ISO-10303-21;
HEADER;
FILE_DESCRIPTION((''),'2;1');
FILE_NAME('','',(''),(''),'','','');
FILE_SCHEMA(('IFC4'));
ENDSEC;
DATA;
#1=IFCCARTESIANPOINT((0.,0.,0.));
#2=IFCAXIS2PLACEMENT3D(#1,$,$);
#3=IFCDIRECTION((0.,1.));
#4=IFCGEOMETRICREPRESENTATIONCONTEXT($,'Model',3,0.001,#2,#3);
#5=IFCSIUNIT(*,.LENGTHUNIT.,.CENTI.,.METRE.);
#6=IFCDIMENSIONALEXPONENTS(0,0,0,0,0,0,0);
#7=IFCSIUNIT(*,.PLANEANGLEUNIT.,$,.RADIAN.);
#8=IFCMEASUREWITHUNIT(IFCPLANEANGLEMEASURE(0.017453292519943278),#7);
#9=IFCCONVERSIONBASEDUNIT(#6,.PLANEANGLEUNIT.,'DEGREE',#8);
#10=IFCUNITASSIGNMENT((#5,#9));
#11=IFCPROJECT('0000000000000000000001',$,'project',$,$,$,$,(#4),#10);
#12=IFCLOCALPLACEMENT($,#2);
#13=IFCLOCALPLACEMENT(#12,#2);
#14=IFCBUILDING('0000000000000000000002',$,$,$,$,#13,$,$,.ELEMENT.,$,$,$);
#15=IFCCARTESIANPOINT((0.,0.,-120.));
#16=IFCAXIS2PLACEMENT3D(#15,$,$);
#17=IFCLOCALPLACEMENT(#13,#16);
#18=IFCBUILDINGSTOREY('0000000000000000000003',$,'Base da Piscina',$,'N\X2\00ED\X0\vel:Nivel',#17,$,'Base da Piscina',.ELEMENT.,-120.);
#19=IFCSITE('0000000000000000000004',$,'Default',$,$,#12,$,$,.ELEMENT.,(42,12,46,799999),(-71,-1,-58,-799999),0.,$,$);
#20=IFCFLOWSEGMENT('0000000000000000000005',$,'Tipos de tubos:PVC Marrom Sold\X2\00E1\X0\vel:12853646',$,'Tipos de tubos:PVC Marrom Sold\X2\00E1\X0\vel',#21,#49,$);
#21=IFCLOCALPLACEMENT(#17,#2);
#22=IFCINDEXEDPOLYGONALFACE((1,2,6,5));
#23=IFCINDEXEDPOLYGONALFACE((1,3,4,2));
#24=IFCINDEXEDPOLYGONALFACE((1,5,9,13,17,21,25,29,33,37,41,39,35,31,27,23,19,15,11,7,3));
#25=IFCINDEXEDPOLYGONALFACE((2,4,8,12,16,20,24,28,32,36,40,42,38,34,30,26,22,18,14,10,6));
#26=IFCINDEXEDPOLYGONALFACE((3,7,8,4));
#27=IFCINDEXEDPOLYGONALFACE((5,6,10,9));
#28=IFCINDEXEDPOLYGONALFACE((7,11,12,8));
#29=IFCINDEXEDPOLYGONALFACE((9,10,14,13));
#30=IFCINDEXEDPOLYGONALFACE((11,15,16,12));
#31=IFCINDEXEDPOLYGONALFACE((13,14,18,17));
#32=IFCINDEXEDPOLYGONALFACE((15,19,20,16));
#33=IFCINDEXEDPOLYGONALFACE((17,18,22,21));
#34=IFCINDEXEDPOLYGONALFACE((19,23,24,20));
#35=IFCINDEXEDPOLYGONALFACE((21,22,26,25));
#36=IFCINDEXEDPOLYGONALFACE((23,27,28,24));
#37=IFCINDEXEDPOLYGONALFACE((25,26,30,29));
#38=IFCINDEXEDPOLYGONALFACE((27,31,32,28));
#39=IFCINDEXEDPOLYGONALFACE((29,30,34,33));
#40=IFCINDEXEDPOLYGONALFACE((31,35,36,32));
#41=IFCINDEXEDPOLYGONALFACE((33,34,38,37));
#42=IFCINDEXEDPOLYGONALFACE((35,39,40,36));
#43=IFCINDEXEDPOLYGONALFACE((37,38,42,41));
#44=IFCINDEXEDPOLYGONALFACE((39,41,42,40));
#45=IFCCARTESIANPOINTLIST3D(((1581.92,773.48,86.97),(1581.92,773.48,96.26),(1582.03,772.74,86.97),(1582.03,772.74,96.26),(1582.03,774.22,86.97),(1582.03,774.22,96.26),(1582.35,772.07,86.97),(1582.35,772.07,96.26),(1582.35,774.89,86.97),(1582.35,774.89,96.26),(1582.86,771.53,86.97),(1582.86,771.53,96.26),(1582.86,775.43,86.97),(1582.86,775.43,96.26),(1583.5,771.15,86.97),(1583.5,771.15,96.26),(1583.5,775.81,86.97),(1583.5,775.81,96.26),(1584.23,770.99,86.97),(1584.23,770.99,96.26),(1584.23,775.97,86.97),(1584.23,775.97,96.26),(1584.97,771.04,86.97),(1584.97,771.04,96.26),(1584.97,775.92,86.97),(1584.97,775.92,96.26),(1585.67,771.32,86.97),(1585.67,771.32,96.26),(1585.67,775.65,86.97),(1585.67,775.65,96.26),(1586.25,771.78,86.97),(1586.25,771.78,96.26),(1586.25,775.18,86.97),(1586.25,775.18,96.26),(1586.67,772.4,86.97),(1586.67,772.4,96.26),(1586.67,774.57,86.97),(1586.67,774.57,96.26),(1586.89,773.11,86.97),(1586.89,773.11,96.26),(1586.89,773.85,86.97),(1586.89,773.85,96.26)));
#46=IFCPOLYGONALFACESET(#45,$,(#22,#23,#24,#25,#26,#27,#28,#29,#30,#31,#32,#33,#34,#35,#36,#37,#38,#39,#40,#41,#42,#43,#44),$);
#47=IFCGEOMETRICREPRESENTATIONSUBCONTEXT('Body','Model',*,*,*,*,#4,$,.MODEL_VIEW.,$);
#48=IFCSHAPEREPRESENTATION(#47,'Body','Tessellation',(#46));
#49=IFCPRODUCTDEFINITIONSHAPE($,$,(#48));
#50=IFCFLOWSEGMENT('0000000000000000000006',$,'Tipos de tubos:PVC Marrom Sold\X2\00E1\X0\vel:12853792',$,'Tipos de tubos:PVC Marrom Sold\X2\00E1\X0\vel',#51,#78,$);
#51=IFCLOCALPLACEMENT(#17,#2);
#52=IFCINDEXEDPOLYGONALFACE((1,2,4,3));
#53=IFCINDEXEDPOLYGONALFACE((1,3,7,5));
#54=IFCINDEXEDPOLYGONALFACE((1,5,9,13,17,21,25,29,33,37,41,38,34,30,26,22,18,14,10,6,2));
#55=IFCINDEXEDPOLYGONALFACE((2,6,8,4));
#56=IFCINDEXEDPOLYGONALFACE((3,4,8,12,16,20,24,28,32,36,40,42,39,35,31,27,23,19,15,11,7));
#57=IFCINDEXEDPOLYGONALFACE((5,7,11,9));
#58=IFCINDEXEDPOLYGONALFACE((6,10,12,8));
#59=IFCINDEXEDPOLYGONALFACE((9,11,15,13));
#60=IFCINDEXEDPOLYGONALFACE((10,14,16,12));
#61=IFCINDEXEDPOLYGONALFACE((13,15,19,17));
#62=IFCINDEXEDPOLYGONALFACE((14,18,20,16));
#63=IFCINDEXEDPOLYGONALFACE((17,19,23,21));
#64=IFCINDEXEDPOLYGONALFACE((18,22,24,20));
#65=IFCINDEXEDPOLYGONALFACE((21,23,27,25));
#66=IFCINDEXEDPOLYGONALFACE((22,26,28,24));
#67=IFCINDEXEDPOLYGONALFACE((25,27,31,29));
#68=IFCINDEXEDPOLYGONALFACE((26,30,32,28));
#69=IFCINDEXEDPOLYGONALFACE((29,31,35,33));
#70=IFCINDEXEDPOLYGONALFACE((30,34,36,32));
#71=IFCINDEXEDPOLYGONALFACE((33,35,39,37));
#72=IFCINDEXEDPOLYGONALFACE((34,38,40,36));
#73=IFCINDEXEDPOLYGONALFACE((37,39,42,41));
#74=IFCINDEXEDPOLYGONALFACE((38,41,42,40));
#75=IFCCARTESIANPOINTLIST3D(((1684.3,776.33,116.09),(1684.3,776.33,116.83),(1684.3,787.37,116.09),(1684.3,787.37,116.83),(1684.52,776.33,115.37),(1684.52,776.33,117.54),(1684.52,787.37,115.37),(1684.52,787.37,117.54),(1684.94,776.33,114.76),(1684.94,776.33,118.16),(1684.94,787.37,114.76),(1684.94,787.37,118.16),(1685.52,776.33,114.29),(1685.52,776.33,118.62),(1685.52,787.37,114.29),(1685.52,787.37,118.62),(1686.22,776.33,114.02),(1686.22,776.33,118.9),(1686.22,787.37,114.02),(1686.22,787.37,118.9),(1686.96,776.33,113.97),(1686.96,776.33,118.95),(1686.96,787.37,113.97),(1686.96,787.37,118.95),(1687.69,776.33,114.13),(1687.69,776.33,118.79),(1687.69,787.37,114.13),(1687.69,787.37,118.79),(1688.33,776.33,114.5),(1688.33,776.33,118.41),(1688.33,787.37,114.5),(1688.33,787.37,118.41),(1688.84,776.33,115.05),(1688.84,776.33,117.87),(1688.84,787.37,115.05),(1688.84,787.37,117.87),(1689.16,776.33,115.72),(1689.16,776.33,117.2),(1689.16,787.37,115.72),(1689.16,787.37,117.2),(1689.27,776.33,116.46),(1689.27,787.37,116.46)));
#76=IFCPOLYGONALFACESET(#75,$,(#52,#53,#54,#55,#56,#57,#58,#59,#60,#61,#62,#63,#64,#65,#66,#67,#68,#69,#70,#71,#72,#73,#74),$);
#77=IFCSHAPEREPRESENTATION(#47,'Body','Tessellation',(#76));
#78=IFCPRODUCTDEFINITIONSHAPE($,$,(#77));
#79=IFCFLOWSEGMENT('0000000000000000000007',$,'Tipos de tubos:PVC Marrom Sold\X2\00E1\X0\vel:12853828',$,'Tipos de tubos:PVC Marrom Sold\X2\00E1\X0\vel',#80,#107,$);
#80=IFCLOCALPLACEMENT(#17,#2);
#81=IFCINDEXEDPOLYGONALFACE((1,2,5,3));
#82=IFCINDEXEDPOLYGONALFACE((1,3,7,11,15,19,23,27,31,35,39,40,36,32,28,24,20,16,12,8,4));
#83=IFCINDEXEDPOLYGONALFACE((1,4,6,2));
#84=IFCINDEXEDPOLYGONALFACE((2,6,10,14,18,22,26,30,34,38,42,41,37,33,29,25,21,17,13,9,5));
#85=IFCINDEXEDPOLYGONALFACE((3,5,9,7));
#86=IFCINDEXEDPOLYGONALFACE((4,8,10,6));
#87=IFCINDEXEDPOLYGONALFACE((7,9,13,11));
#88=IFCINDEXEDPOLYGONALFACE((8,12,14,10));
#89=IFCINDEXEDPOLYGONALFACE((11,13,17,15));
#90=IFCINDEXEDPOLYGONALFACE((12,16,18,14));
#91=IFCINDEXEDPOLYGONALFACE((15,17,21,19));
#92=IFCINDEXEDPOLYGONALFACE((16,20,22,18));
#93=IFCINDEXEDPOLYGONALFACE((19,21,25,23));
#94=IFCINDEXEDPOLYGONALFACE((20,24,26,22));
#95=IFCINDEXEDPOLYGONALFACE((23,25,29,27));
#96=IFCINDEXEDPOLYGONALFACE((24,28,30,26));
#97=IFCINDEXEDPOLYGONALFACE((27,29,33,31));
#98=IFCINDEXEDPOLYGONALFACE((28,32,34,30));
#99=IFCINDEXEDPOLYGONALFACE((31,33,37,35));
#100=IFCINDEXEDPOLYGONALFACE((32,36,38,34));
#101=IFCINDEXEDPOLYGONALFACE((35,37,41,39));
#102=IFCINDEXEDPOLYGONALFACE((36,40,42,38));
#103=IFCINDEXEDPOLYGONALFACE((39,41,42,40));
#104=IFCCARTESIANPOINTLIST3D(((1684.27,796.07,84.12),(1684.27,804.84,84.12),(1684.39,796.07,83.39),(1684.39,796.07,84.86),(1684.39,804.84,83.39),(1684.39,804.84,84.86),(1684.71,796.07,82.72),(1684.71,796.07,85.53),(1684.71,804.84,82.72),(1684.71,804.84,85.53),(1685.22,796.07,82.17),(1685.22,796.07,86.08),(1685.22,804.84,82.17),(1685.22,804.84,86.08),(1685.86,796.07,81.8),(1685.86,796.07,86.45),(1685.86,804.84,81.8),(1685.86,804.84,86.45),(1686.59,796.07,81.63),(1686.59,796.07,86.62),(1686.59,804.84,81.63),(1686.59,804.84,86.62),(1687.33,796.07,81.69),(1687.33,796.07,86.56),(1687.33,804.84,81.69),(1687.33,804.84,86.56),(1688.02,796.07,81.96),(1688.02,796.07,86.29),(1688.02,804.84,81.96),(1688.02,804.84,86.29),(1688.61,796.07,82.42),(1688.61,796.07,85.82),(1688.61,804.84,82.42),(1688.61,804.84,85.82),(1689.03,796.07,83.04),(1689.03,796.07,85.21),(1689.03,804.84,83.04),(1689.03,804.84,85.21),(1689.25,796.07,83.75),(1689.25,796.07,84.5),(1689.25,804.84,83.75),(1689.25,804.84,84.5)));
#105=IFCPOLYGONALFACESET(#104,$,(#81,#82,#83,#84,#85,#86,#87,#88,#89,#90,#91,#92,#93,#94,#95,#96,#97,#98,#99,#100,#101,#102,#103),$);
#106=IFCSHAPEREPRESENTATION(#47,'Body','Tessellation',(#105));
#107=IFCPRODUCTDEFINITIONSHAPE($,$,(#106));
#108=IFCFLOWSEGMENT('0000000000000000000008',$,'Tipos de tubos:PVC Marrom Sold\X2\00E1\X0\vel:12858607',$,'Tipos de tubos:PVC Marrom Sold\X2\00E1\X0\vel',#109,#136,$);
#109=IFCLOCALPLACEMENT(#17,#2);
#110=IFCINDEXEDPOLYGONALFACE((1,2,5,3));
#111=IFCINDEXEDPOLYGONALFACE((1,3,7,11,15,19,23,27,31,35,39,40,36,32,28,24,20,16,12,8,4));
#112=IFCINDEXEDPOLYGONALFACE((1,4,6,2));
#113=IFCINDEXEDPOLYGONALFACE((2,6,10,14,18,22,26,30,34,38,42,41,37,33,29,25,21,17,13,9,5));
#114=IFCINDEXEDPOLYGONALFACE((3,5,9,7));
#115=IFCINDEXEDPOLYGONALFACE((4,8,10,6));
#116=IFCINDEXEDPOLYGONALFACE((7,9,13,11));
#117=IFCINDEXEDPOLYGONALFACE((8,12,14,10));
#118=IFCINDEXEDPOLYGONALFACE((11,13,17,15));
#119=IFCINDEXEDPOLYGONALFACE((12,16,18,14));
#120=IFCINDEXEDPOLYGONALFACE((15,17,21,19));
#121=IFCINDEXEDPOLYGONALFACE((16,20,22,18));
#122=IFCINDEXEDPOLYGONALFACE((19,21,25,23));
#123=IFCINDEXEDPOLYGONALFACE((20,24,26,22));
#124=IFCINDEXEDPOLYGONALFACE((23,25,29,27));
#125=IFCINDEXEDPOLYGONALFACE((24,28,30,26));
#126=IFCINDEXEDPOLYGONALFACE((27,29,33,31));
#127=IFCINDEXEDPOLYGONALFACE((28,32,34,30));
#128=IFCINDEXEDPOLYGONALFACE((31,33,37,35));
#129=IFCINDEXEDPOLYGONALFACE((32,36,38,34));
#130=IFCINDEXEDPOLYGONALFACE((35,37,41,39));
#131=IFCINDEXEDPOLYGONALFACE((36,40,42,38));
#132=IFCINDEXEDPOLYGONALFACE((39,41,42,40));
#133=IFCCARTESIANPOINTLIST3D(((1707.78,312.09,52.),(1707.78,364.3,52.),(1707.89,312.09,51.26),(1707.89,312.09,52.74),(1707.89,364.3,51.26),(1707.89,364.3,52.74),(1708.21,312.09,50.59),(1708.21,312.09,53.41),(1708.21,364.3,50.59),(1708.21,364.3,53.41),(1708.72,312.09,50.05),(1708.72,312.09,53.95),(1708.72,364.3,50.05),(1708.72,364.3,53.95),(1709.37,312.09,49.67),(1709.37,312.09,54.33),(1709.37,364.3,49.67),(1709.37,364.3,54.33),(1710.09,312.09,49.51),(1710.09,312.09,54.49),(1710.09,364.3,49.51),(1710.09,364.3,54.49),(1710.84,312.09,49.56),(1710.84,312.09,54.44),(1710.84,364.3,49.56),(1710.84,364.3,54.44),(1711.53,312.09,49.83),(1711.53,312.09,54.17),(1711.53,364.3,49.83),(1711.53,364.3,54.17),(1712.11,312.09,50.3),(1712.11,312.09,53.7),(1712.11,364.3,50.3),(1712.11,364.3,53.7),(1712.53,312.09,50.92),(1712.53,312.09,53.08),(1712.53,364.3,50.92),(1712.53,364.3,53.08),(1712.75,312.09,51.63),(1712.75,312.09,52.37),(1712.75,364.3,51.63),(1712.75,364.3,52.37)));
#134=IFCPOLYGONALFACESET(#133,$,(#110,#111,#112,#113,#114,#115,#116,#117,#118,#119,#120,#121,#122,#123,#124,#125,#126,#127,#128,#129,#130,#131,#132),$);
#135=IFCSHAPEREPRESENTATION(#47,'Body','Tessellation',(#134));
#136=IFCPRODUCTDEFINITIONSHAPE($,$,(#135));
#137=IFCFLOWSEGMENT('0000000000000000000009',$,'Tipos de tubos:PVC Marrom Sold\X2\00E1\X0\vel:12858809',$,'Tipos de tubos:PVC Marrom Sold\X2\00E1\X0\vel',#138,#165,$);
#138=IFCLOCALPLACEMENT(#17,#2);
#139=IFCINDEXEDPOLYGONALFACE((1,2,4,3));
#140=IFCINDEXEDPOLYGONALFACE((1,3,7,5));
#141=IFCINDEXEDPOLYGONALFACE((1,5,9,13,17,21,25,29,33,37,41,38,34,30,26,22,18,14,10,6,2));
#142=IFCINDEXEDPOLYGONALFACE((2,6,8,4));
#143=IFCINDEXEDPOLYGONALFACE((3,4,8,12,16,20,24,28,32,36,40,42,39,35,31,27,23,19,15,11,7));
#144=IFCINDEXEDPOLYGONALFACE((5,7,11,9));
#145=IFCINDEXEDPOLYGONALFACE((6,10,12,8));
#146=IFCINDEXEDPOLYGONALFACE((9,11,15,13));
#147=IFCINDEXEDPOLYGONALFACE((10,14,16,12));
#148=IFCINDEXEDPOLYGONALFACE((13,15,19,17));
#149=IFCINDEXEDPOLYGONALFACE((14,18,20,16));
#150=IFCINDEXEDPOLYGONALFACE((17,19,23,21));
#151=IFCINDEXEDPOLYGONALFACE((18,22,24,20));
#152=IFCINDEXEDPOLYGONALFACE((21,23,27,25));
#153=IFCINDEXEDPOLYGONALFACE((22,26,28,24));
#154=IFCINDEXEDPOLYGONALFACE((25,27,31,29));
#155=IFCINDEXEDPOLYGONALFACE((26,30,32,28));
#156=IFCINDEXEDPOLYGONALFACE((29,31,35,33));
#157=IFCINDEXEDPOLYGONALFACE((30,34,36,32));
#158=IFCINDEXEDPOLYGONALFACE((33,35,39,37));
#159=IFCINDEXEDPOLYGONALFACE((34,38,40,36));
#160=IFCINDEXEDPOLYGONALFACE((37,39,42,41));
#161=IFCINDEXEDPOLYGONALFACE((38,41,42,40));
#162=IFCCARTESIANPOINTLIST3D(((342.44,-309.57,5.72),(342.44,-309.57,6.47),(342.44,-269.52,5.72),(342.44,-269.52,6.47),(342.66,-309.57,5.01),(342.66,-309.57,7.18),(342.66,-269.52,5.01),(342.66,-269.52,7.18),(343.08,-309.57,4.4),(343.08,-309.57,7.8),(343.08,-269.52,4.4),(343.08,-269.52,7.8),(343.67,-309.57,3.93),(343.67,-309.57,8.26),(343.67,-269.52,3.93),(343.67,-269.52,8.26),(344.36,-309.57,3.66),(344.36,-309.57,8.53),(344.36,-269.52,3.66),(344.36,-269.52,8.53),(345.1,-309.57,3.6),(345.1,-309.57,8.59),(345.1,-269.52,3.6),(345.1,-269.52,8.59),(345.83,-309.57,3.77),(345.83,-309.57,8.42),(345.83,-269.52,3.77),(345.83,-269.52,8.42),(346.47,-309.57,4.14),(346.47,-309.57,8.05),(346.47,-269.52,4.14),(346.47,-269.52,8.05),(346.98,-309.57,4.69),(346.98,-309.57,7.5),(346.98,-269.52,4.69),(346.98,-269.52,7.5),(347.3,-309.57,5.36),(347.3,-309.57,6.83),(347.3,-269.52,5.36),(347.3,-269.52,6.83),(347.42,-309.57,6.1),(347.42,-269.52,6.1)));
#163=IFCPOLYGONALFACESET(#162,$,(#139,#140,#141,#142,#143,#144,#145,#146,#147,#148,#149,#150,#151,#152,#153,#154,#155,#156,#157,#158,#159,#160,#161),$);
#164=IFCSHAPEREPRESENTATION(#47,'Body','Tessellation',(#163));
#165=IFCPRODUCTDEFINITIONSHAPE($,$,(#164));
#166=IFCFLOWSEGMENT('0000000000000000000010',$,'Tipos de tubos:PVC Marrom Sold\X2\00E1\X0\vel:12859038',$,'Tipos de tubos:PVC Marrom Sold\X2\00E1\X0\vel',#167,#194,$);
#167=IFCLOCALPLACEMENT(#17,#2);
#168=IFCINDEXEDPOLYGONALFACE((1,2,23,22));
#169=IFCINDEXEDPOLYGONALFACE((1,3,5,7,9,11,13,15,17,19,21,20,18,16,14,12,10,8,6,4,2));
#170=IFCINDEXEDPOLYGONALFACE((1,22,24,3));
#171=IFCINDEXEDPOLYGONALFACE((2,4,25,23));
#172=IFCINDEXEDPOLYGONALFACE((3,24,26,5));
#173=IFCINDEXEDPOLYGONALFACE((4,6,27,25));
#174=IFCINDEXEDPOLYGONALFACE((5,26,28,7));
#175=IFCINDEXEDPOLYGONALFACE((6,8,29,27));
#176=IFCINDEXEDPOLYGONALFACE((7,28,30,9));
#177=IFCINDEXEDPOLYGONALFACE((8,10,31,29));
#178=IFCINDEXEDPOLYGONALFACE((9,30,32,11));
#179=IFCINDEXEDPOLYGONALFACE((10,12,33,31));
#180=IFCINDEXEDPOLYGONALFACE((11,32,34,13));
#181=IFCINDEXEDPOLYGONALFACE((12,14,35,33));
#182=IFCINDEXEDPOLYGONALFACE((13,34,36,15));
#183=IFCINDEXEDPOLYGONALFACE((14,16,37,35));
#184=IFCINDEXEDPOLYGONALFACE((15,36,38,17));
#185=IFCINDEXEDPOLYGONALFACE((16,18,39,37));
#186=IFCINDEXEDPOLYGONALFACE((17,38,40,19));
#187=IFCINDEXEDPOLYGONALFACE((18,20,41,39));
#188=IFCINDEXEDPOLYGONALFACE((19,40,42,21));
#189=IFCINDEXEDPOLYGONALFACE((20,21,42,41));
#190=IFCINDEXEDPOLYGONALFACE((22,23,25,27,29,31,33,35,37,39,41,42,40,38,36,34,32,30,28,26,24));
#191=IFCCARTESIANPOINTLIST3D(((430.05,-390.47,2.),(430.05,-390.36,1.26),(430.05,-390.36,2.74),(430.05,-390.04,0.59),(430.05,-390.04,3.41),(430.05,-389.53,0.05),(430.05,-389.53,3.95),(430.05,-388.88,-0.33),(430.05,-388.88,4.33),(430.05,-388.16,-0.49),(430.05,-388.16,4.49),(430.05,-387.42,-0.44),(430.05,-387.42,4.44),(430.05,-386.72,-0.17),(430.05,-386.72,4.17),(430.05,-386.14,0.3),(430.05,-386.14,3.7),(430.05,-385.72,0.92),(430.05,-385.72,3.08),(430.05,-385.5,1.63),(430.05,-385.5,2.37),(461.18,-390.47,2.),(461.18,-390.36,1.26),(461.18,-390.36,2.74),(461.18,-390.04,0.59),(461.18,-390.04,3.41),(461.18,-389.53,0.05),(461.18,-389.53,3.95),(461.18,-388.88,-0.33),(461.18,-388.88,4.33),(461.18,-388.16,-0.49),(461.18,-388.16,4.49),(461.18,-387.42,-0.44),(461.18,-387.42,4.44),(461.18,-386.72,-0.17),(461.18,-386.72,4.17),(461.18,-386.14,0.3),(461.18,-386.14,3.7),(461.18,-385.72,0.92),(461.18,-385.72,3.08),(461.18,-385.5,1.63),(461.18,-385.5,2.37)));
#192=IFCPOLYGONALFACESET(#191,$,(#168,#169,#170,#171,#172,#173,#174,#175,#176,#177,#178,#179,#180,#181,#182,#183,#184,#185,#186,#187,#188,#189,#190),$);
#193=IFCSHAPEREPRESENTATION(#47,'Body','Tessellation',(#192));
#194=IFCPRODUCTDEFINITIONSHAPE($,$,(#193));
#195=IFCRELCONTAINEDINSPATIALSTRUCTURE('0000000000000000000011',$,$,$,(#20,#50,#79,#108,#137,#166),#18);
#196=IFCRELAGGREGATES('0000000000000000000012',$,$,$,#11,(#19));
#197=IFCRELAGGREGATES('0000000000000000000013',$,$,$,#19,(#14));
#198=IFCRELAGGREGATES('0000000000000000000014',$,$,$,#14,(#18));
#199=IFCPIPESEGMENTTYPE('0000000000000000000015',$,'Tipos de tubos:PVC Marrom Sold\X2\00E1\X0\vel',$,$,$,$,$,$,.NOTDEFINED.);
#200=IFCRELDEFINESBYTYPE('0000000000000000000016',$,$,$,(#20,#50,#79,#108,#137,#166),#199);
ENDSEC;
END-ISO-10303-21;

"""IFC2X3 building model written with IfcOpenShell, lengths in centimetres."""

from ifc_helpers import new_model, entity, si_unit, converted_unit, direction, frame, frame_2d, origin, origin_2d_with_axis, place, context, subcontext, project, spatial, circle, extrude, type_object, element, save


model = new_model("IFC2X3")

# Units and contexts
model_context = context("Model", 3, precision=0.001, world=origin(), true_north=direction((0.0, 1.0)))
body_context = subcontext(model_context, "Body", "Model", "MODEL_VIEW")
ifc_project = project(units=[si_unit("LENGTHUNIT", "METRE", prefix="CENTI"), converted_unit("PLANEANGLEUNIT", "DEGREE", entity("IfcPlaneAngleMeasure", 0.017453292519943278), si_unit("PLANEANGLEUNIT", "RADIAN"), dimensions=[0, 0, 0, 0, 0, 0, 0])], contexts=[model_context])

# Site, building, storey
site_placement = place(None, origin())
site = spatial("IfcSite", under=ifc_project, at=site_placement, Name="Default", CompositionType="ELEMENT", RefLatitude=(42, 12, 46, 799999), RefLongitude=(-71, -1, -58, -799999), RefElevation=0.0)
building_placement = place(site_placement, origin())
building = spatial("IfcBuilding", under=site, at=building_placement, CompositionType="ELEMENT")
storey_placement = place(building_placement, frame((0.0, 0.0, -120.0)))
storey = spatial("IfcBuildingStorey", under=building, at=storey_placement, Name="Base da Piscina", ObjectType="Nível:Nivel", LongName="Base da Piscina", CompositionType="ELEMENT", Elevation=-120.0)

# Flow segments
pipe_segment_type = type_object("IfcPipeSegmentType", Name="Tipos de tubos:PVC Marrom Soldável", PredefinedType="NOTDEFINED")
flow_segment_1_placement = place(storey_placement, origin())
element("IfcFlowSegment", 1, at=flow_segment_1_placement, inside=storey, type_object=pipe_segment_type, Name="Tipos de tubos:PVC Marrom Soldável:12853646", ObjectType="Tipos de tubos:PVC Marrom Soldável", context=body_context, shape_type="SweptSolid", body=[
    extrude(circle(Radius=2.5, at=origin_2d_with_axis()), frame((1584.42, 773.48, 86.97), z_axis=(0.0, 0.0, 1.0), x_axis=(-1.0, 0.0, 0.0)), (0.0, 0.0, 1.0), 9.29),
])
flow_segment_2_placement = place(storey_placement, origin())
element("IfcFlowSegment", 2, at=flow_segment_2_placement, inside=storey, type_object=pipe_segment_type, Name="Tipos de tubos:PVC Marrom Soldável:12853792", ObjectType="Tipos de tubos:PVC Marrom Soldável", context=body_context, shape_type="SweptSolid", body=[
    extrude(circle(Radius=2.5, at=frame_2d((0.0, 0.0), x_axis=(1.0, 0.0))), frame((1686.77, 776.33, 116.46), z_axis=(0.0, 1.0, -0.000062), x_axis=(1.0, 0.0, 0.0)), (0.0, 0.0, 1.0), 11.04),
])
flow_segment_3_placement = place(storey_placement, origin())
element("IfcFlowSegment", 3, at=flow_segment_3_placement, inside=storey, type_object=pipe_segment_type, Name="Tipos de tubos:PVC Marrom Soldável:12853828", ObjectType="Tipos de tubos:PVC Marrom Soldável", context=body_context, shape_type="SweptSolid", body=[
    extrude(circle(Radius=2.5, at=origin_2d_with_axis()), frame((1686.77, 796.07, 84.12), z_axis=(0.0, 1.0, 0.0), x_axis=(-1.0, 0.0, 0.0)), (0.0, 0.0, 1.0), 8.78),
])
flow_segment_4_placement = place(storey_placement, origin())
element("IfcFlowSegment", 4, at=flow_segment_4_placement, inside=storey, type_object=pipe_segment_type, Name="Tipos de tubos:PVC Marrom Soldável:12858607", ObjectType="Tipos de tubos:PVC Marrom Soldável", context=body_context, shape_type="SweptSolid", body=[
    extrude(circle(Radius=2.5, at=origin_2d_with_axis()), frame((1710.28, 312.09, 52.0), z_axis=(0.0, 1.0, 0.0), x_axis=(-1.0, 0.0, 0.0)), (0.0, 0.0, 1.0), 52.21),
])
flow_segment_5_placement = place(storey_placement, origin())
element("IfcFlowSegment", 5, at=flow_segment_5_placement, inside=storey, type_object=pipe_segment_type, Name="Tipos de tubos:PVC Marrom Soldável:12858809", ObjectType="Tipos de tubos:PVC Marrom Soldável", context=body_context, shape_type="SweptSolid", body=[
    extrude(circle(Radius=2.5, at=origin_2d_with_axis()), frame((344.92, -309.57, 6.1), z_axis=(0.0, 1.0, 0.0), x_axis=(1.0, 0.0, 0.0)), (0.0, 0.0, 1.0), 40.05),
])
flow_segment_6_placement = place(storey_placement, origin())
element("IfcFlowSegment", 6, at=flow_segment_6_placement, inside=storey, type_object=pipe_segment_type, Name="Tipos de tubos:PVC Marrom Soldável:12859038", ObjectType="Tipos de tubos:PVC Marrom Soldável", context=body_context, shape_type="SweptSolid", body=[
    extrude(circle(Radius=2.5, at=origin_2d_with_axis()), frame((430.05, -387.97, 2.0), z_axis=(1.0, 0.0, 0.0), x_axis=(0.0, -1.0, 0.0)), (0.0, 0.0, 1.0), 31.13),
])

save(model, "model.ifc")
